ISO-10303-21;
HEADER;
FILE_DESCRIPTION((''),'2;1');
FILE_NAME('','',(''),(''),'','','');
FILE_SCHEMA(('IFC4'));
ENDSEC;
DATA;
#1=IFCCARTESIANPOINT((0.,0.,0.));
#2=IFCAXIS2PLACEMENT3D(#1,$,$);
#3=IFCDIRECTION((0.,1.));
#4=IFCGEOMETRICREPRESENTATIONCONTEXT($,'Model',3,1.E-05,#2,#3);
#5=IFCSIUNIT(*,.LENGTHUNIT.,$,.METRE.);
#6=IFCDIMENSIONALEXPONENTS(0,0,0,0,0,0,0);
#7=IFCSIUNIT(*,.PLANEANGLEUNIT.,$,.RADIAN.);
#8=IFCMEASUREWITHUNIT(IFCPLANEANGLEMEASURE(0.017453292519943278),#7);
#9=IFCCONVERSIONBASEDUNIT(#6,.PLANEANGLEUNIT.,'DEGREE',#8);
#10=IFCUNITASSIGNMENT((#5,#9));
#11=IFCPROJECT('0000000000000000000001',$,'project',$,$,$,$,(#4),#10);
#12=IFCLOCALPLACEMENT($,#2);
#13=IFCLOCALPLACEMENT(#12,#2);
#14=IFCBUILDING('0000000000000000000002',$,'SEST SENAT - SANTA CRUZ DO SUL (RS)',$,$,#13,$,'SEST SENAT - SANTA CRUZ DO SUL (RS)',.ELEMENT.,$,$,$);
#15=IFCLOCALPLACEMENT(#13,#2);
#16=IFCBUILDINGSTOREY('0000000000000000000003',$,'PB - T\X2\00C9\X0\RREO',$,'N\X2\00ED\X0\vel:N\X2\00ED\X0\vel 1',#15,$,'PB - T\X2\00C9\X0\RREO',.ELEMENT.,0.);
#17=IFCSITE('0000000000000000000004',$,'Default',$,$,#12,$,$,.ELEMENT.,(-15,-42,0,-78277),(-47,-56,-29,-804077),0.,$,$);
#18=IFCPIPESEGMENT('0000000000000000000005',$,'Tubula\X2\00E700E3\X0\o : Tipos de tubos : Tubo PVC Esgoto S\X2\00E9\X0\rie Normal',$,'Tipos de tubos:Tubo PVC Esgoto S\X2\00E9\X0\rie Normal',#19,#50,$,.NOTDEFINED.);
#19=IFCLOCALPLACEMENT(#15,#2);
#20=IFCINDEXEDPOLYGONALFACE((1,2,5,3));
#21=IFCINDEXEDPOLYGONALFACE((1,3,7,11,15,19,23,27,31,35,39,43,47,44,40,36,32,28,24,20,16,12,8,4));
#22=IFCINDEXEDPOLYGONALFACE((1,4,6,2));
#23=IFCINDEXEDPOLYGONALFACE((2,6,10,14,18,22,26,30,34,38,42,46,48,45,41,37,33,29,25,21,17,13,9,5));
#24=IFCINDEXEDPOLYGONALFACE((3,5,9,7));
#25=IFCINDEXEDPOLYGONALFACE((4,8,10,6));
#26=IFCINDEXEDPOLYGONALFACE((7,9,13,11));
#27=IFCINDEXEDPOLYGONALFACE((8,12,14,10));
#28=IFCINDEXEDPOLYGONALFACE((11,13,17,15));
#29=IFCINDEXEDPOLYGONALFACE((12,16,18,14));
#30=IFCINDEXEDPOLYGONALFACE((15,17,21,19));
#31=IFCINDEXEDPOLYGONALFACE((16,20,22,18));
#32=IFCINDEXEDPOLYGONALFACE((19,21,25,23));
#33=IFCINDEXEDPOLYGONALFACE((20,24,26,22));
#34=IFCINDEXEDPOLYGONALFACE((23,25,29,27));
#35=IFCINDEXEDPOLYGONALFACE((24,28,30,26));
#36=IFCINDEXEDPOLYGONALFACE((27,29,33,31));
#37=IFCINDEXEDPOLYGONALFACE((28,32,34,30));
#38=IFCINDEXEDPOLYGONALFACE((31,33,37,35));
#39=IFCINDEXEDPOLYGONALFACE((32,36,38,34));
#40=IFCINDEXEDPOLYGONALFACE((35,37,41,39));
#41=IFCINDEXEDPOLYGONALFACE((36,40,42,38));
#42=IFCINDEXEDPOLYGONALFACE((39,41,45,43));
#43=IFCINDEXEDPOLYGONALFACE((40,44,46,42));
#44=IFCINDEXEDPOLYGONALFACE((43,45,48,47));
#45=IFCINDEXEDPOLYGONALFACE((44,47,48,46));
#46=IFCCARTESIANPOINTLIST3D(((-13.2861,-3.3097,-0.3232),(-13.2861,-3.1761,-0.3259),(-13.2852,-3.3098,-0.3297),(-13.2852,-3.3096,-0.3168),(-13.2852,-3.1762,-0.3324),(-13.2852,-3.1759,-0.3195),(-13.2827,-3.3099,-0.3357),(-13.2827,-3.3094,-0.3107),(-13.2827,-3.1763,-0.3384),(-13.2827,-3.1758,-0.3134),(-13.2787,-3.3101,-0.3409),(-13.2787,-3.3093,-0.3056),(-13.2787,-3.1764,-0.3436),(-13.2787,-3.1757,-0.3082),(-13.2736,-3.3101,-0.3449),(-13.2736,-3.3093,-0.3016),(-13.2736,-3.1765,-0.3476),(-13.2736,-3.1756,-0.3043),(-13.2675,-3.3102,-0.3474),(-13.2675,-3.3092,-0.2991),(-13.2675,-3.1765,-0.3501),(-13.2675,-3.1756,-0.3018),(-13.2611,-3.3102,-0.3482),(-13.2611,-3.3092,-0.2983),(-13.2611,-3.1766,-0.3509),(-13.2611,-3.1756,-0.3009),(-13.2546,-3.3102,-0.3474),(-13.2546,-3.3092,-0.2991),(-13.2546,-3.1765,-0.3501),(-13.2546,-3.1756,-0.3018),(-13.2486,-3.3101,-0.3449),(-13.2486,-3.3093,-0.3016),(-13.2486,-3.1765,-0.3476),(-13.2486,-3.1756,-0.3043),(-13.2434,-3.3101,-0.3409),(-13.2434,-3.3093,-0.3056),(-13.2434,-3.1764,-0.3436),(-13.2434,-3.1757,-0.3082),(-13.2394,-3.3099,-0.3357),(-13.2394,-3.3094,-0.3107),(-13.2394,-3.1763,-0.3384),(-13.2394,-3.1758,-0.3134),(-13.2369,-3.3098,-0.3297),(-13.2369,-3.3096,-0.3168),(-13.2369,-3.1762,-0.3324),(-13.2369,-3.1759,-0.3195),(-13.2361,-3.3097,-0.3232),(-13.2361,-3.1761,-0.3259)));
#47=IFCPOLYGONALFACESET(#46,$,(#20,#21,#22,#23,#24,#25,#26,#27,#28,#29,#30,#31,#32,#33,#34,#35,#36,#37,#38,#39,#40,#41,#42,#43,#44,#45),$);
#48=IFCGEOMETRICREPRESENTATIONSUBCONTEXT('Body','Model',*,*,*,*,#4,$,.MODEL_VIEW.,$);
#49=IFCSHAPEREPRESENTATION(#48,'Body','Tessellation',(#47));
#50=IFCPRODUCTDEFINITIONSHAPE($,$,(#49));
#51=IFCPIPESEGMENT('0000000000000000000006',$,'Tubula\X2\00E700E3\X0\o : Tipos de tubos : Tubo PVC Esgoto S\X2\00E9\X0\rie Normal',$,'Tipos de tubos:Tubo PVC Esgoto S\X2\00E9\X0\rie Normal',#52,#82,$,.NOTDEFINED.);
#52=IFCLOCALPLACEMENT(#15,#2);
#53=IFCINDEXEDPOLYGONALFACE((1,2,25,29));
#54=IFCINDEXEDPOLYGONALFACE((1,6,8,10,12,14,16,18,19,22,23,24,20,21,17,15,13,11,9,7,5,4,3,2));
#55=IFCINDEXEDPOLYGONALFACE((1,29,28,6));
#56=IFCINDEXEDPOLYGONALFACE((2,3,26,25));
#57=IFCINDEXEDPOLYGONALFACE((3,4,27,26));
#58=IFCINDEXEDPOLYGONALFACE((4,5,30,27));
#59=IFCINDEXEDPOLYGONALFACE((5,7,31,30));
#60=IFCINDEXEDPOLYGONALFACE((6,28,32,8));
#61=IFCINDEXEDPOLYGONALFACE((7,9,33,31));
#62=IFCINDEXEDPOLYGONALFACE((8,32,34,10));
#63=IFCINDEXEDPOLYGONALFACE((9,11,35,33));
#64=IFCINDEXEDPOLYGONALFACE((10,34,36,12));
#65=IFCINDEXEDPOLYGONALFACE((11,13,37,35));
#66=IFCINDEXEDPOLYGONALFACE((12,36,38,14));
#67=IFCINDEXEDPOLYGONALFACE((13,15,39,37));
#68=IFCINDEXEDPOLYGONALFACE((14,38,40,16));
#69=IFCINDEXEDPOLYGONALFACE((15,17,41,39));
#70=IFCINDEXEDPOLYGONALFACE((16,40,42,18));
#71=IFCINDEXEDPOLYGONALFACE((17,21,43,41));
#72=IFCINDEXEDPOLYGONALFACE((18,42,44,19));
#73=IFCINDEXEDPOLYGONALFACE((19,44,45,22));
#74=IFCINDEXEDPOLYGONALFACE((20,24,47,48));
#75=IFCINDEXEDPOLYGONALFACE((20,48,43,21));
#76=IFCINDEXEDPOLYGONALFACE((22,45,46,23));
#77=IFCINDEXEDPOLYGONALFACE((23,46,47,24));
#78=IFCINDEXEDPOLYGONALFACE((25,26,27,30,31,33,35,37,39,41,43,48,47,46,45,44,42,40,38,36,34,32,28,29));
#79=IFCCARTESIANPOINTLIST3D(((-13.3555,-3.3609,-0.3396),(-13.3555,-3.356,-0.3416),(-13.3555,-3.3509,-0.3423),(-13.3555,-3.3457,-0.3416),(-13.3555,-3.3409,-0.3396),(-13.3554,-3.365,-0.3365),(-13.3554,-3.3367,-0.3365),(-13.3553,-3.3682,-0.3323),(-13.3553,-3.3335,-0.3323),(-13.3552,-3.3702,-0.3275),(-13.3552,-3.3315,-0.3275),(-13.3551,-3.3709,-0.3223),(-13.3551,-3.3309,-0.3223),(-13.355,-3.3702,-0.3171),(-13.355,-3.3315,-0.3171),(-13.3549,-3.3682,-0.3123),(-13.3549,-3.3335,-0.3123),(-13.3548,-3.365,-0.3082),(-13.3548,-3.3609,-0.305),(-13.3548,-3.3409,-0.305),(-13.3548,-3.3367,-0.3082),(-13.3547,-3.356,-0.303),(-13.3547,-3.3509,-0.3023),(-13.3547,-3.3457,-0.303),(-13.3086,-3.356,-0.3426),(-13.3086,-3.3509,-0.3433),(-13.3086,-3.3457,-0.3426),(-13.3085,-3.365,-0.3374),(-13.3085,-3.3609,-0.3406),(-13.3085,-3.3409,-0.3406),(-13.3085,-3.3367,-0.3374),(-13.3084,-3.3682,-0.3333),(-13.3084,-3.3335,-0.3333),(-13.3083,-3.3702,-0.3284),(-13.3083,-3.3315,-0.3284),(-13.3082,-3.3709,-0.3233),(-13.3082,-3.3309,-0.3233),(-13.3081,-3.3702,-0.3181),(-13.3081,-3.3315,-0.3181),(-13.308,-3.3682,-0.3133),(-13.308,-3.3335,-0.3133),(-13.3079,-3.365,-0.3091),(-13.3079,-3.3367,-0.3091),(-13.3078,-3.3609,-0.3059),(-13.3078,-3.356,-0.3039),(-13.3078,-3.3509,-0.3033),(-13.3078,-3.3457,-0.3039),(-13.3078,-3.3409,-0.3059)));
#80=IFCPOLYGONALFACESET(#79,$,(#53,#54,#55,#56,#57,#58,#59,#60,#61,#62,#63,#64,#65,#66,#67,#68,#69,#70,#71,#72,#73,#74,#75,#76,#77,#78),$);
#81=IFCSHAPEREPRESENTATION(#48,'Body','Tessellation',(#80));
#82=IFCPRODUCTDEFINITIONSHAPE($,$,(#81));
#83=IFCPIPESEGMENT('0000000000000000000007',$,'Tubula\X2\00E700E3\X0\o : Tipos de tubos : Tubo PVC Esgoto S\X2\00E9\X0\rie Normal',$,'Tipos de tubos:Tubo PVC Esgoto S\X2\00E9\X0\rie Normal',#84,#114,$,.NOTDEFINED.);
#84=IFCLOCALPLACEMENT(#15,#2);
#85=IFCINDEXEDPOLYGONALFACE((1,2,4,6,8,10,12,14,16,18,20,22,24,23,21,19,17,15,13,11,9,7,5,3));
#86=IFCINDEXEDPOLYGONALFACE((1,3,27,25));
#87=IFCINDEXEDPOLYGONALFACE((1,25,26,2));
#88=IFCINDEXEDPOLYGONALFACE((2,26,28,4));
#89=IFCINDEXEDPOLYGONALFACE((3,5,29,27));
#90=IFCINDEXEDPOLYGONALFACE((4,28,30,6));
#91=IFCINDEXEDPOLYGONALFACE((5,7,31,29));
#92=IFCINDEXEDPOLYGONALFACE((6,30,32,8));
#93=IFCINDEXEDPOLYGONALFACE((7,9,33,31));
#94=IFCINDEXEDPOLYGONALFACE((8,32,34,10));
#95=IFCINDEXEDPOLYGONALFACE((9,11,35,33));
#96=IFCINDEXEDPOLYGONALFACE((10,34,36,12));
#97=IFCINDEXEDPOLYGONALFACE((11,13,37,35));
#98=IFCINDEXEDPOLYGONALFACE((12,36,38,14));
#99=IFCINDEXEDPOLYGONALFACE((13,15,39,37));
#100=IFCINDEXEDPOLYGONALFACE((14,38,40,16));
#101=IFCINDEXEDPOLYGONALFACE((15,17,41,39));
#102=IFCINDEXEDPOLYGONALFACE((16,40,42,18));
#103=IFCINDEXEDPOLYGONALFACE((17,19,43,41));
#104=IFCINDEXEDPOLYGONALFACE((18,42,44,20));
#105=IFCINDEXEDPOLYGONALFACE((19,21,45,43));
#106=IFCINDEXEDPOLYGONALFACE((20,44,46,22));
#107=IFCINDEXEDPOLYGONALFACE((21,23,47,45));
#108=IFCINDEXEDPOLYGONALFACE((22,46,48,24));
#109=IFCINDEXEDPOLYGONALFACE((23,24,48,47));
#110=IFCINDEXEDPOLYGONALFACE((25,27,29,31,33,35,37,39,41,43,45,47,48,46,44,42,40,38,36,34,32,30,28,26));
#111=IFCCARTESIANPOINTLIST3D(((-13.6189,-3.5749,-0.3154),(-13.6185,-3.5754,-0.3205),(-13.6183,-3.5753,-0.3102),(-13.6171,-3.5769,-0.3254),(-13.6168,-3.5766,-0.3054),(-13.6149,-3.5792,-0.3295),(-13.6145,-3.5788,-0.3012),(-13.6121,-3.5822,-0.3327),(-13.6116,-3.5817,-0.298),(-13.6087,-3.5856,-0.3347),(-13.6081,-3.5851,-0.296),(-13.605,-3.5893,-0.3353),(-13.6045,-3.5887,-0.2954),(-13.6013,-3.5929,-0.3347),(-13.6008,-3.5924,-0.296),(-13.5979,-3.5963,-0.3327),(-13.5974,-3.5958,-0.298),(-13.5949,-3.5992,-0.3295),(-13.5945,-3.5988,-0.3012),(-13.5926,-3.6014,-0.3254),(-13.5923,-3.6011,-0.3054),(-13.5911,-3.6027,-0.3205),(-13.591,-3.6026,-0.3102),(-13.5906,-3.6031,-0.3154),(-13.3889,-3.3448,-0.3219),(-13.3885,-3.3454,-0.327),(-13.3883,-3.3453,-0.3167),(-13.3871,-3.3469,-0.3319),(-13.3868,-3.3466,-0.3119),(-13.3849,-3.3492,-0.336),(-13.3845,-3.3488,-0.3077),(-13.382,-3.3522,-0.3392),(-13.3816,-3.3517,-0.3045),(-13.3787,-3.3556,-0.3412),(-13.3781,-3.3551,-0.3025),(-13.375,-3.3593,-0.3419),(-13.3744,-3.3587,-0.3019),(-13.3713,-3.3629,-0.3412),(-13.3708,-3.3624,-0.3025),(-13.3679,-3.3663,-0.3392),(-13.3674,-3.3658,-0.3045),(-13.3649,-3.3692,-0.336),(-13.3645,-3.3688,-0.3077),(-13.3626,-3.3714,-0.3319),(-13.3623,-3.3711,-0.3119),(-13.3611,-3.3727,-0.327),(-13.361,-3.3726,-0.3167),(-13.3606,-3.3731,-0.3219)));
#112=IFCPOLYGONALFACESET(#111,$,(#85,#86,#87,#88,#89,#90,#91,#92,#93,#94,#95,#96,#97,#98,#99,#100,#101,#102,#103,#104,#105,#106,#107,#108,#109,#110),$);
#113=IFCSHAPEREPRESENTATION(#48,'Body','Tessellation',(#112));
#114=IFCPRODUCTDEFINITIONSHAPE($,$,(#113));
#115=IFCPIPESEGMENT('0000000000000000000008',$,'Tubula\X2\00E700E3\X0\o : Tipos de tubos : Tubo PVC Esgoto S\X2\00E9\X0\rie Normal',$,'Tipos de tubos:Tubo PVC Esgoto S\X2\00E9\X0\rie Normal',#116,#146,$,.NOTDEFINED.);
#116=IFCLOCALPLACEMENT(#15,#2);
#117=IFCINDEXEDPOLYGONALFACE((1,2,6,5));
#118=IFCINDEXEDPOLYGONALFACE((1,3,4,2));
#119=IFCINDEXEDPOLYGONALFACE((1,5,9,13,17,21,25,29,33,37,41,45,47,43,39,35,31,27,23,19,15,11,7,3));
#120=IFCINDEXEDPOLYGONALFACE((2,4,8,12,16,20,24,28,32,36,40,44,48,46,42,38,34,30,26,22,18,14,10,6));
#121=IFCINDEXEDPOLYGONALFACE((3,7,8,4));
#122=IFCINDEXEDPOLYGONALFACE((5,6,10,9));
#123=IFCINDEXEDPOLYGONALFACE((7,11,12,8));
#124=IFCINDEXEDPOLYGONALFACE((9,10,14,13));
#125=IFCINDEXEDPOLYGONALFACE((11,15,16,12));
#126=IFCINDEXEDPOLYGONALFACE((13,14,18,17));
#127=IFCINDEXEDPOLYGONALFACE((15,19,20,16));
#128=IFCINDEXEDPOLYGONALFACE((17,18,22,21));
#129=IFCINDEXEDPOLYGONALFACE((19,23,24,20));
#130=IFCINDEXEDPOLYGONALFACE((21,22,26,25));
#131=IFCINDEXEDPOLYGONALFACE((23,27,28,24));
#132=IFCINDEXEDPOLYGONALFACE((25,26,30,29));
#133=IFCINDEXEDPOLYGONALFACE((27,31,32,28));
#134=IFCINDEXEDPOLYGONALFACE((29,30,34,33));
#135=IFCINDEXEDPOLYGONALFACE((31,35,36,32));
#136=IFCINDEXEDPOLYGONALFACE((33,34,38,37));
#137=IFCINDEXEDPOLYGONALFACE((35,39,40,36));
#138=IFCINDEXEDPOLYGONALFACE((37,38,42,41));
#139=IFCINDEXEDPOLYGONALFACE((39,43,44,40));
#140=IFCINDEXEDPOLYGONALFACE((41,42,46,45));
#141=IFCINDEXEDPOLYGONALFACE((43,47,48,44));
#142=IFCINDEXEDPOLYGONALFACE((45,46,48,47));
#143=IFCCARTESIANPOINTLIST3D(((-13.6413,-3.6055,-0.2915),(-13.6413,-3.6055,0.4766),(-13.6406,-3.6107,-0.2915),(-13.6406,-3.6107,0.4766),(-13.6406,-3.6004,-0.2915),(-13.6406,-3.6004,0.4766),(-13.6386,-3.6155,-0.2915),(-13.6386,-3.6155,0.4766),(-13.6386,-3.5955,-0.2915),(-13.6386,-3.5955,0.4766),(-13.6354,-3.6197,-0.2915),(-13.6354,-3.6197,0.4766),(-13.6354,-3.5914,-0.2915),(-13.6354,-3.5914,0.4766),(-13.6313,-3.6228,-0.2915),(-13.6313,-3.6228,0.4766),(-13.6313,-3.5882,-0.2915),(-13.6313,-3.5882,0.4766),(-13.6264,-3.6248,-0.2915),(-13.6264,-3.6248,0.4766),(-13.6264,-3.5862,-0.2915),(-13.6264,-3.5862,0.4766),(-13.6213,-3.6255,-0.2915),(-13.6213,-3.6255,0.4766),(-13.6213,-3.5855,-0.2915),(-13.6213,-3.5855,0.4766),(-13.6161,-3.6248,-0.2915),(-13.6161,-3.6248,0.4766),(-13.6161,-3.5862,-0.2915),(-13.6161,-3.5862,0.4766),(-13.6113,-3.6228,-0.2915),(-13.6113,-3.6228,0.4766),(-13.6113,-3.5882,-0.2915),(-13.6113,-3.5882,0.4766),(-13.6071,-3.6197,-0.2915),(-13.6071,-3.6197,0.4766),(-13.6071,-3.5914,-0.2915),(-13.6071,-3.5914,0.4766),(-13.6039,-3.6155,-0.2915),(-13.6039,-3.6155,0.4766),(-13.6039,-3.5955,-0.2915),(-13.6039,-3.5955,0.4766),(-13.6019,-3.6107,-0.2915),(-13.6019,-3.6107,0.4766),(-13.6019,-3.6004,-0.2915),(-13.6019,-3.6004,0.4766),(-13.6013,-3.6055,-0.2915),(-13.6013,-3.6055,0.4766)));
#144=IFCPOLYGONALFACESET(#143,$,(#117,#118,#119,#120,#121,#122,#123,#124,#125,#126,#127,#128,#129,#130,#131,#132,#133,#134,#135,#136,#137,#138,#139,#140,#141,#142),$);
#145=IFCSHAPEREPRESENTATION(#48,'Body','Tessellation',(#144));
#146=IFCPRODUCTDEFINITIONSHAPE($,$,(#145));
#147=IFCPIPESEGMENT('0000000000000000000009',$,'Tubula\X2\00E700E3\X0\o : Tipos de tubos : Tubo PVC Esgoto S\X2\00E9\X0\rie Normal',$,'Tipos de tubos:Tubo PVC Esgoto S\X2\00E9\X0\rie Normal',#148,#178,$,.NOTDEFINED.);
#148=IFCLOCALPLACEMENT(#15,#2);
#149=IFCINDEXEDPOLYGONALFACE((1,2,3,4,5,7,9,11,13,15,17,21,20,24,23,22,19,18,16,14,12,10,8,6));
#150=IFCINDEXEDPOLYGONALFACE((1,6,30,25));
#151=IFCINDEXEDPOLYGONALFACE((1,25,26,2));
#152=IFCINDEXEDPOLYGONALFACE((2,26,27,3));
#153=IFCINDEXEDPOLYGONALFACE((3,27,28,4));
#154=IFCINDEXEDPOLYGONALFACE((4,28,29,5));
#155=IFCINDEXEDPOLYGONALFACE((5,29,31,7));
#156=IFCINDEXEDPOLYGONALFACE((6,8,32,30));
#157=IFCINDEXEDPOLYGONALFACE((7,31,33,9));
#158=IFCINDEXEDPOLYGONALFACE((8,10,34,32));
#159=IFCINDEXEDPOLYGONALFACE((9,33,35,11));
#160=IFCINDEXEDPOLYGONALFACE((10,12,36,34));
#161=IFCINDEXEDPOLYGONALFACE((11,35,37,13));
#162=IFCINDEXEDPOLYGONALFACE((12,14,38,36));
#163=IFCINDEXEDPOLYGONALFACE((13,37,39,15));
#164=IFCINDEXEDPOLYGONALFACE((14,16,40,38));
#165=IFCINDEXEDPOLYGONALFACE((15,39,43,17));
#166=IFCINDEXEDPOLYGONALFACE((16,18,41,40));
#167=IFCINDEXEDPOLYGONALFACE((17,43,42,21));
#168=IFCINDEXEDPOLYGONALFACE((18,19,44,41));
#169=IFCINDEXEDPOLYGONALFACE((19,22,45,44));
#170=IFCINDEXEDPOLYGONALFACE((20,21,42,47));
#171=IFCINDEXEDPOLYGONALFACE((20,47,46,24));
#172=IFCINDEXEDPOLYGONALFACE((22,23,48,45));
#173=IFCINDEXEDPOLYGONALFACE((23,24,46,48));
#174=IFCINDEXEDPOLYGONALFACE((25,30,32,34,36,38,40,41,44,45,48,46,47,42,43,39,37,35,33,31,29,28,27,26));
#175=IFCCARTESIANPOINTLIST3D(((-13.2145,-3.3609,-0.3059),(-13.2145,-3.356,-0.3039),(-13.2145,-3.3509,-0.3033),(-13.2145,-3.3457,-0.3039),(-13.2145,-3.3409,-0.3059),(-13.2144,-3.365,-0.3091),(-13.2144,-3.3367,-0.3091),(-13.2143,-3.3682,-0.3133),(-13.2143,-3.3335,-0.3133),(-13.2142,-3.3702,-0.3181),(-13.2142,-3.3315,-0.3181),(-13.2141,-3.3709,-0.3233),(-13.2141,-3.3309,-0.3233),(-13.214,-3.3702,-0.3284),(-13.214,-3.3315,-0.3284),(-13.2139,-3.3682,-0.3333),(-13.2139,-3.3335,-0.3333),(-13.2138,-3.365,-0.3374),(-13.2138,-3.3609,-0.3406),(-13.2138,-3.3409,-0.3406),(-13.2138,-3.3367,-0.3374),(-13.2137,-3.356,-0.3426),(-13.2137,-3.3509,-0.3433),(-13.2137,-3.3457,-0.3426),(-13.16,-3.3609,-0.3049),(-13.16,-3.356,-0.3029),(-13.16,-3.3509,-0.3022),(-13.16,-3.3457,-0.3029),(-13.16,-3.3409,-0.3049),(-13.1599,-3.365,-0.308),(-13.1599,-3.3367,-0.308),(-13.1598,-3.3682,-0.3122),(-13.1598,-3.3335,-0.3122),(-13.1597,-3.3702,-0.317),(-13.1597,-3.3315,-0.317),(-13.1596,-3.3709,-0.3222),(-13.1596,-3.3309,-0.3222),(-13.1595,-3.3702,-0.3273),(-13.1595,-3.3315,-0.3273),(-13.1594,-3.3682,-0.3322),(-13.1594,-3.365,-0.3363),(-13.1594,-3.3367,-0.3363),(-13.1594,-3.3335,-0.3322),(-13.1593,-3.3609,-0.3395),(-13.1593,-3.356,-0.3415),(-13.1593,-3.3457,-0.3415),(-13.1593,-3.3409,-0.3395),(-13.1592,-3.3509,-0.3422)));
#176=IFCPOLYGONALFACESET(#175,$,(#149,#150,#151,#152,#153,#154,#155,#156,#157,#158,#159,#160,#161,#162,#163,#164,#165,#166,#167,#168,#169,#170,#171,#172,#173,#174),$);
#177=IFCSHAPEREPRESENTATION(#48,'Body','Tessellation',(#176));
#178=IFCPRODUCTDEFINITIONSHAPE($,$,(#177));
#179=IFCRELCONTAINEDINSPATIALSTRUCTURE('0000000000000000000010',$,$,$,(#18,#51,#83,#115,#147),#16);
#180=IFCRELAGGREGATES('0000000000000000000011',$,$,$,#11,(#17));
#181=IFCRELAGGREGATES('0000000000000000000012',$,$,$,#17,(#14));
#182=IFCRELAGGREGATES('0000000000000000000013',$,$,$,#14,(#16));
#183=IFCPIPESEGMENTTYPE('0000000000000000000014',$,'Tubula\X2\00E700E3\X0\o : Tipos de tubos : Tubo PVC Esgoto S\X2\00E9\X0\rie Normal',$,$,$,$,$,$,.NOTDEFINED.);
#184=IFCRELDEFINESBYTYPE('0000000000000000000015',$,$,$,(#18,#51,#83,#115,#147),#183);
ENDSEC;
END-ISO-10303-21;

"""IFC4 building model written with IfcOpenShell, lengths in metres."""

from ifc_helpers import new_model, entity, si_unit, converted_unit, direction, frame, origin, place, context, subcontext, project, spatial, arc, indexed_curve, outline, extrude, type_object, element, save


model = new_model("IFC4")

# Units and contexts
model_context = context("Model", 3, precision=1e-05, world=origin(), true_north=direction((0.0, 1.0)))
body_context = subcontext(model_context, "Body", "Model", "MODEL_VIEW")
ifc_project = project(units=[si_unit("LENGTHUNIT", "METRE"), converted_unit("PLANEANGLEUNIT", "DEGREE", entity("IfcPlaneAngleMeasure", 0.017453292519943278), si_unit("PLANEANGLEUNIT", "RADIAN"), dimensions=[0, 0, 0, 0, 0, 0, 0])], contexts=[model_context])

# Site, building, storey
site_placement = place(None, origin())
site = spatial("IfcSite", under=ifc_project, at=site_placement, Name="Default", CompositionType="ELEMENT", RefLatitude=(-15, -42, 0, -78277), RefLongitude=(-47, -56, -29, -804077), RefElevation=0.0)
building_placement = place(site_placement, origin())
building = spatial("IfcBuilding", under=site, at=building_placement, Name="SEST SENAT - SANTA CRUZ DO SUL (RS)", LongName="SEST SENAT - SANTA CRUZ DO SUL (RS)", CompositionType="ELEMENT")
storey_placement = place(building_placement, origin())
storey = spatial("IfcBuildingStorey", under=building, at=storey_placement, Name="PB - TÉRREO", ObjectType="Nível:Nível 1", LongName="PB - TÉRREO", CompositionType="ELEMENT", Elevation=0.0)

# Pipe segments
pipe_segment_type_1 = type_object("IfcPipeSegmentType", Name="Tubulação : Tipos de tubos : Tubo PVC Esgoto Série Normal", PredefinedType="NOTDEFINED")
pipe_segment_1_placement = place(storey_placement, frame((-13.2877, -3.3118, -0.2967)))
element("IfcPipeSegment", 1, at=pipe_segment_1_placement, inside=storey, type_object=pipe_segment_type_1, Name="Tubulação : Tipos de tubos : Tubo PVC Esgoto Série Normal", ObjectType="Tipos de tubos:Tubo PVC Esgoto Série Normal", PredefinedType="NOTDEFINED", context=body_context, shape_type="SweptSolid", body=[
    extrude(outline(indexed_curve([(0.025, 0.0), (0.0177, 0.0177), (0.0, 0.025), (-0.0177, 0.0177), (-0.025, 0.0), (-0.0177, -0.0177), (0.0, -0.025), (0.0177, -0.0177)], segments=[arc(1, 2, 3), arc(3, 4, 5), arc(5, 6, 7), arc(7, 8, 1)], self_intersect=False)), frame((0.0266, 0.0021, -0.0266), z_axis=(0.0, 0.9998, -0.019997), x_axis=(-1.0, 0.0, 0.0)), (0.0, 0.0, 1.0), 0.1337),
])
pipe_segment_2_placement = place(storey_placement, frame((-13.3571, -3.3725, -0.3007)))
element("IfcPipeSegment", 2, at=pipe_segment_2_placement, inside=storey, type_object=pipe_segment_type_1, Name="Tubulação : Tipos de tubos : Tubo PVC Esgoto Série Normal", ObjectType="Tipos de tubos:Tubo PVC Esgoto Série Normal", PredefinedType="NOTDEFINED", context=body_context, shape_type="SweptSolid", body=[
    extrude(outline(indexed_curve([(0.02, 0.0), (0.0141, 0.0141), (0.0, 0.02), (-0.0141, 0.0141), (-0.02, 0.0), (-0.0141, -0.0141), (0.0, -0.02), (0.0141, -0.0141)], segments=[arc(1, 2, 3), arc(3, 4, 5), arc(5, 6, 7), arc(7, 8, 1)], self_intersect=False)), frame((0.0489, 0.0216, -0.0225), z_axis=(-0.9998, 0.0, 0.019996), x_axis=(0.0, 1.0, 0.0)), (0.0, 0.0, 1.0), 0.0469),
])
pipe_segment_3_placement = place(storey_placement, frame((-13.6205, -3.6047, -0.2938)))
element("IfcPipeSegment", 3, at=pipe_segment_3_placement, inside=storey, type_object=pipe_segment_type_1, Name="Tubulação : Tipos de tubos : Tubo PVC Esgoto Série Normal", ObjectType="Tipos de tubos:Tubo PVC Esgoto Série Normal", PredefinedType="NOTDEFINED", context=body_context, shape_type="SweptSolid", body=[
    extrude(outline(indexed_curve([(0.02, 0.0), (0.0141, 0.0141), (0.0, 0.02), (-0.0141, 0.0141), (-0.02, 0.0), (-0.0141, -0.0141), (0.0, -0.02), (0.0141, -0.0141)], segments=[arc(1, 2, 3), arc(3, 4, 5), arc(5, 6, 7), arc(7, 8, 1)], self_intersect=False)), frame((0.0157, 0.0157, -0.0216), z_axis=(0.706965, 0.706965, -0.019996), x_axis=(-0.707107, 0.707107, 0.0)), (0.0, 0.0, 1.0), 0.3253),
])
pipe_segment_4_placement = place(storey_placement, frame((-13.6429, -3.6271, -0.2915)))
element("IfcPipeSegment", 4, at=pipe_segment_4_placement, inside=storey, type_object=pipe_segment_type_1, Name="Tubulação : Tipos de tubos : Tubo PVC Esgoto Série Normal", ObjectType="Tipos de tubos:Tubo PVC Esgoto Série Normal", PredefinedType="NOTDEFINED", context=body_context, shape_type="SweptSolid", body=[
    extrude(outline(indexed_curve([(0.02, 0.0), (0.0141, 0.0141), (0.0, 0.02), (-0.0141, 0.0141), (-0.02, 0.0), (-0.0141, -0.0141), (0.0, -0.02), (0.0141, -0.0141)], segments=[arc(1, 2, 3), arc(3, 4, 5), arc(5, 6, 7), arc(7, 8, 1)], self_intersect=False)), frame((0.0216, 0.0216, 0.0), z_axis=(0.0, 0.0, 1.0), x_axis=(-1.0, 0.0, 0.0)), (0.0, 0.0, 1.0), 0.7681),
])
pipe_segment_5_placement = place(storey_placement, frame((-13.2161, -3.3725, -0.3448)))
element("IfcPipeSegment", 5, at=pipe_segment_5_placement, inside=storey, type_object=pipe_segment_type_1, Name="Tubulação : Tipos de tubos : Tubo PVC Esgoto Série Normal", ObjectType="Tipos de tubos:Tubo PVC Esgoto Série Normal", PredefinedType="NOTDEFINED", context=body_context, shape_type="SweptSolid", body=[
    extrude(outline(indexed_curve([(0.02, 0.0), (0.0141, 0.0141), (0.0, 0.02), (-0.0141, 0.0141), (-0.02, 0.0), (-0.0141, -0.0141), (0.0, -0.02), (0.0141, -0.0141)], segments=[arc(1, 2, 3), arc(3, 4, 5), arc(5, 6, 7), arc(7, 8, 1)], self_intersect=False)), frame((0.002, 0.0216, 0.0216), z_axis=(0.9998, 0.0, 0.019996), x_axis=(0.0, -1.0, 0.0)), (0.0, 0.0, 1.0), 0.0545),
])

save(model, "model.ifc")
